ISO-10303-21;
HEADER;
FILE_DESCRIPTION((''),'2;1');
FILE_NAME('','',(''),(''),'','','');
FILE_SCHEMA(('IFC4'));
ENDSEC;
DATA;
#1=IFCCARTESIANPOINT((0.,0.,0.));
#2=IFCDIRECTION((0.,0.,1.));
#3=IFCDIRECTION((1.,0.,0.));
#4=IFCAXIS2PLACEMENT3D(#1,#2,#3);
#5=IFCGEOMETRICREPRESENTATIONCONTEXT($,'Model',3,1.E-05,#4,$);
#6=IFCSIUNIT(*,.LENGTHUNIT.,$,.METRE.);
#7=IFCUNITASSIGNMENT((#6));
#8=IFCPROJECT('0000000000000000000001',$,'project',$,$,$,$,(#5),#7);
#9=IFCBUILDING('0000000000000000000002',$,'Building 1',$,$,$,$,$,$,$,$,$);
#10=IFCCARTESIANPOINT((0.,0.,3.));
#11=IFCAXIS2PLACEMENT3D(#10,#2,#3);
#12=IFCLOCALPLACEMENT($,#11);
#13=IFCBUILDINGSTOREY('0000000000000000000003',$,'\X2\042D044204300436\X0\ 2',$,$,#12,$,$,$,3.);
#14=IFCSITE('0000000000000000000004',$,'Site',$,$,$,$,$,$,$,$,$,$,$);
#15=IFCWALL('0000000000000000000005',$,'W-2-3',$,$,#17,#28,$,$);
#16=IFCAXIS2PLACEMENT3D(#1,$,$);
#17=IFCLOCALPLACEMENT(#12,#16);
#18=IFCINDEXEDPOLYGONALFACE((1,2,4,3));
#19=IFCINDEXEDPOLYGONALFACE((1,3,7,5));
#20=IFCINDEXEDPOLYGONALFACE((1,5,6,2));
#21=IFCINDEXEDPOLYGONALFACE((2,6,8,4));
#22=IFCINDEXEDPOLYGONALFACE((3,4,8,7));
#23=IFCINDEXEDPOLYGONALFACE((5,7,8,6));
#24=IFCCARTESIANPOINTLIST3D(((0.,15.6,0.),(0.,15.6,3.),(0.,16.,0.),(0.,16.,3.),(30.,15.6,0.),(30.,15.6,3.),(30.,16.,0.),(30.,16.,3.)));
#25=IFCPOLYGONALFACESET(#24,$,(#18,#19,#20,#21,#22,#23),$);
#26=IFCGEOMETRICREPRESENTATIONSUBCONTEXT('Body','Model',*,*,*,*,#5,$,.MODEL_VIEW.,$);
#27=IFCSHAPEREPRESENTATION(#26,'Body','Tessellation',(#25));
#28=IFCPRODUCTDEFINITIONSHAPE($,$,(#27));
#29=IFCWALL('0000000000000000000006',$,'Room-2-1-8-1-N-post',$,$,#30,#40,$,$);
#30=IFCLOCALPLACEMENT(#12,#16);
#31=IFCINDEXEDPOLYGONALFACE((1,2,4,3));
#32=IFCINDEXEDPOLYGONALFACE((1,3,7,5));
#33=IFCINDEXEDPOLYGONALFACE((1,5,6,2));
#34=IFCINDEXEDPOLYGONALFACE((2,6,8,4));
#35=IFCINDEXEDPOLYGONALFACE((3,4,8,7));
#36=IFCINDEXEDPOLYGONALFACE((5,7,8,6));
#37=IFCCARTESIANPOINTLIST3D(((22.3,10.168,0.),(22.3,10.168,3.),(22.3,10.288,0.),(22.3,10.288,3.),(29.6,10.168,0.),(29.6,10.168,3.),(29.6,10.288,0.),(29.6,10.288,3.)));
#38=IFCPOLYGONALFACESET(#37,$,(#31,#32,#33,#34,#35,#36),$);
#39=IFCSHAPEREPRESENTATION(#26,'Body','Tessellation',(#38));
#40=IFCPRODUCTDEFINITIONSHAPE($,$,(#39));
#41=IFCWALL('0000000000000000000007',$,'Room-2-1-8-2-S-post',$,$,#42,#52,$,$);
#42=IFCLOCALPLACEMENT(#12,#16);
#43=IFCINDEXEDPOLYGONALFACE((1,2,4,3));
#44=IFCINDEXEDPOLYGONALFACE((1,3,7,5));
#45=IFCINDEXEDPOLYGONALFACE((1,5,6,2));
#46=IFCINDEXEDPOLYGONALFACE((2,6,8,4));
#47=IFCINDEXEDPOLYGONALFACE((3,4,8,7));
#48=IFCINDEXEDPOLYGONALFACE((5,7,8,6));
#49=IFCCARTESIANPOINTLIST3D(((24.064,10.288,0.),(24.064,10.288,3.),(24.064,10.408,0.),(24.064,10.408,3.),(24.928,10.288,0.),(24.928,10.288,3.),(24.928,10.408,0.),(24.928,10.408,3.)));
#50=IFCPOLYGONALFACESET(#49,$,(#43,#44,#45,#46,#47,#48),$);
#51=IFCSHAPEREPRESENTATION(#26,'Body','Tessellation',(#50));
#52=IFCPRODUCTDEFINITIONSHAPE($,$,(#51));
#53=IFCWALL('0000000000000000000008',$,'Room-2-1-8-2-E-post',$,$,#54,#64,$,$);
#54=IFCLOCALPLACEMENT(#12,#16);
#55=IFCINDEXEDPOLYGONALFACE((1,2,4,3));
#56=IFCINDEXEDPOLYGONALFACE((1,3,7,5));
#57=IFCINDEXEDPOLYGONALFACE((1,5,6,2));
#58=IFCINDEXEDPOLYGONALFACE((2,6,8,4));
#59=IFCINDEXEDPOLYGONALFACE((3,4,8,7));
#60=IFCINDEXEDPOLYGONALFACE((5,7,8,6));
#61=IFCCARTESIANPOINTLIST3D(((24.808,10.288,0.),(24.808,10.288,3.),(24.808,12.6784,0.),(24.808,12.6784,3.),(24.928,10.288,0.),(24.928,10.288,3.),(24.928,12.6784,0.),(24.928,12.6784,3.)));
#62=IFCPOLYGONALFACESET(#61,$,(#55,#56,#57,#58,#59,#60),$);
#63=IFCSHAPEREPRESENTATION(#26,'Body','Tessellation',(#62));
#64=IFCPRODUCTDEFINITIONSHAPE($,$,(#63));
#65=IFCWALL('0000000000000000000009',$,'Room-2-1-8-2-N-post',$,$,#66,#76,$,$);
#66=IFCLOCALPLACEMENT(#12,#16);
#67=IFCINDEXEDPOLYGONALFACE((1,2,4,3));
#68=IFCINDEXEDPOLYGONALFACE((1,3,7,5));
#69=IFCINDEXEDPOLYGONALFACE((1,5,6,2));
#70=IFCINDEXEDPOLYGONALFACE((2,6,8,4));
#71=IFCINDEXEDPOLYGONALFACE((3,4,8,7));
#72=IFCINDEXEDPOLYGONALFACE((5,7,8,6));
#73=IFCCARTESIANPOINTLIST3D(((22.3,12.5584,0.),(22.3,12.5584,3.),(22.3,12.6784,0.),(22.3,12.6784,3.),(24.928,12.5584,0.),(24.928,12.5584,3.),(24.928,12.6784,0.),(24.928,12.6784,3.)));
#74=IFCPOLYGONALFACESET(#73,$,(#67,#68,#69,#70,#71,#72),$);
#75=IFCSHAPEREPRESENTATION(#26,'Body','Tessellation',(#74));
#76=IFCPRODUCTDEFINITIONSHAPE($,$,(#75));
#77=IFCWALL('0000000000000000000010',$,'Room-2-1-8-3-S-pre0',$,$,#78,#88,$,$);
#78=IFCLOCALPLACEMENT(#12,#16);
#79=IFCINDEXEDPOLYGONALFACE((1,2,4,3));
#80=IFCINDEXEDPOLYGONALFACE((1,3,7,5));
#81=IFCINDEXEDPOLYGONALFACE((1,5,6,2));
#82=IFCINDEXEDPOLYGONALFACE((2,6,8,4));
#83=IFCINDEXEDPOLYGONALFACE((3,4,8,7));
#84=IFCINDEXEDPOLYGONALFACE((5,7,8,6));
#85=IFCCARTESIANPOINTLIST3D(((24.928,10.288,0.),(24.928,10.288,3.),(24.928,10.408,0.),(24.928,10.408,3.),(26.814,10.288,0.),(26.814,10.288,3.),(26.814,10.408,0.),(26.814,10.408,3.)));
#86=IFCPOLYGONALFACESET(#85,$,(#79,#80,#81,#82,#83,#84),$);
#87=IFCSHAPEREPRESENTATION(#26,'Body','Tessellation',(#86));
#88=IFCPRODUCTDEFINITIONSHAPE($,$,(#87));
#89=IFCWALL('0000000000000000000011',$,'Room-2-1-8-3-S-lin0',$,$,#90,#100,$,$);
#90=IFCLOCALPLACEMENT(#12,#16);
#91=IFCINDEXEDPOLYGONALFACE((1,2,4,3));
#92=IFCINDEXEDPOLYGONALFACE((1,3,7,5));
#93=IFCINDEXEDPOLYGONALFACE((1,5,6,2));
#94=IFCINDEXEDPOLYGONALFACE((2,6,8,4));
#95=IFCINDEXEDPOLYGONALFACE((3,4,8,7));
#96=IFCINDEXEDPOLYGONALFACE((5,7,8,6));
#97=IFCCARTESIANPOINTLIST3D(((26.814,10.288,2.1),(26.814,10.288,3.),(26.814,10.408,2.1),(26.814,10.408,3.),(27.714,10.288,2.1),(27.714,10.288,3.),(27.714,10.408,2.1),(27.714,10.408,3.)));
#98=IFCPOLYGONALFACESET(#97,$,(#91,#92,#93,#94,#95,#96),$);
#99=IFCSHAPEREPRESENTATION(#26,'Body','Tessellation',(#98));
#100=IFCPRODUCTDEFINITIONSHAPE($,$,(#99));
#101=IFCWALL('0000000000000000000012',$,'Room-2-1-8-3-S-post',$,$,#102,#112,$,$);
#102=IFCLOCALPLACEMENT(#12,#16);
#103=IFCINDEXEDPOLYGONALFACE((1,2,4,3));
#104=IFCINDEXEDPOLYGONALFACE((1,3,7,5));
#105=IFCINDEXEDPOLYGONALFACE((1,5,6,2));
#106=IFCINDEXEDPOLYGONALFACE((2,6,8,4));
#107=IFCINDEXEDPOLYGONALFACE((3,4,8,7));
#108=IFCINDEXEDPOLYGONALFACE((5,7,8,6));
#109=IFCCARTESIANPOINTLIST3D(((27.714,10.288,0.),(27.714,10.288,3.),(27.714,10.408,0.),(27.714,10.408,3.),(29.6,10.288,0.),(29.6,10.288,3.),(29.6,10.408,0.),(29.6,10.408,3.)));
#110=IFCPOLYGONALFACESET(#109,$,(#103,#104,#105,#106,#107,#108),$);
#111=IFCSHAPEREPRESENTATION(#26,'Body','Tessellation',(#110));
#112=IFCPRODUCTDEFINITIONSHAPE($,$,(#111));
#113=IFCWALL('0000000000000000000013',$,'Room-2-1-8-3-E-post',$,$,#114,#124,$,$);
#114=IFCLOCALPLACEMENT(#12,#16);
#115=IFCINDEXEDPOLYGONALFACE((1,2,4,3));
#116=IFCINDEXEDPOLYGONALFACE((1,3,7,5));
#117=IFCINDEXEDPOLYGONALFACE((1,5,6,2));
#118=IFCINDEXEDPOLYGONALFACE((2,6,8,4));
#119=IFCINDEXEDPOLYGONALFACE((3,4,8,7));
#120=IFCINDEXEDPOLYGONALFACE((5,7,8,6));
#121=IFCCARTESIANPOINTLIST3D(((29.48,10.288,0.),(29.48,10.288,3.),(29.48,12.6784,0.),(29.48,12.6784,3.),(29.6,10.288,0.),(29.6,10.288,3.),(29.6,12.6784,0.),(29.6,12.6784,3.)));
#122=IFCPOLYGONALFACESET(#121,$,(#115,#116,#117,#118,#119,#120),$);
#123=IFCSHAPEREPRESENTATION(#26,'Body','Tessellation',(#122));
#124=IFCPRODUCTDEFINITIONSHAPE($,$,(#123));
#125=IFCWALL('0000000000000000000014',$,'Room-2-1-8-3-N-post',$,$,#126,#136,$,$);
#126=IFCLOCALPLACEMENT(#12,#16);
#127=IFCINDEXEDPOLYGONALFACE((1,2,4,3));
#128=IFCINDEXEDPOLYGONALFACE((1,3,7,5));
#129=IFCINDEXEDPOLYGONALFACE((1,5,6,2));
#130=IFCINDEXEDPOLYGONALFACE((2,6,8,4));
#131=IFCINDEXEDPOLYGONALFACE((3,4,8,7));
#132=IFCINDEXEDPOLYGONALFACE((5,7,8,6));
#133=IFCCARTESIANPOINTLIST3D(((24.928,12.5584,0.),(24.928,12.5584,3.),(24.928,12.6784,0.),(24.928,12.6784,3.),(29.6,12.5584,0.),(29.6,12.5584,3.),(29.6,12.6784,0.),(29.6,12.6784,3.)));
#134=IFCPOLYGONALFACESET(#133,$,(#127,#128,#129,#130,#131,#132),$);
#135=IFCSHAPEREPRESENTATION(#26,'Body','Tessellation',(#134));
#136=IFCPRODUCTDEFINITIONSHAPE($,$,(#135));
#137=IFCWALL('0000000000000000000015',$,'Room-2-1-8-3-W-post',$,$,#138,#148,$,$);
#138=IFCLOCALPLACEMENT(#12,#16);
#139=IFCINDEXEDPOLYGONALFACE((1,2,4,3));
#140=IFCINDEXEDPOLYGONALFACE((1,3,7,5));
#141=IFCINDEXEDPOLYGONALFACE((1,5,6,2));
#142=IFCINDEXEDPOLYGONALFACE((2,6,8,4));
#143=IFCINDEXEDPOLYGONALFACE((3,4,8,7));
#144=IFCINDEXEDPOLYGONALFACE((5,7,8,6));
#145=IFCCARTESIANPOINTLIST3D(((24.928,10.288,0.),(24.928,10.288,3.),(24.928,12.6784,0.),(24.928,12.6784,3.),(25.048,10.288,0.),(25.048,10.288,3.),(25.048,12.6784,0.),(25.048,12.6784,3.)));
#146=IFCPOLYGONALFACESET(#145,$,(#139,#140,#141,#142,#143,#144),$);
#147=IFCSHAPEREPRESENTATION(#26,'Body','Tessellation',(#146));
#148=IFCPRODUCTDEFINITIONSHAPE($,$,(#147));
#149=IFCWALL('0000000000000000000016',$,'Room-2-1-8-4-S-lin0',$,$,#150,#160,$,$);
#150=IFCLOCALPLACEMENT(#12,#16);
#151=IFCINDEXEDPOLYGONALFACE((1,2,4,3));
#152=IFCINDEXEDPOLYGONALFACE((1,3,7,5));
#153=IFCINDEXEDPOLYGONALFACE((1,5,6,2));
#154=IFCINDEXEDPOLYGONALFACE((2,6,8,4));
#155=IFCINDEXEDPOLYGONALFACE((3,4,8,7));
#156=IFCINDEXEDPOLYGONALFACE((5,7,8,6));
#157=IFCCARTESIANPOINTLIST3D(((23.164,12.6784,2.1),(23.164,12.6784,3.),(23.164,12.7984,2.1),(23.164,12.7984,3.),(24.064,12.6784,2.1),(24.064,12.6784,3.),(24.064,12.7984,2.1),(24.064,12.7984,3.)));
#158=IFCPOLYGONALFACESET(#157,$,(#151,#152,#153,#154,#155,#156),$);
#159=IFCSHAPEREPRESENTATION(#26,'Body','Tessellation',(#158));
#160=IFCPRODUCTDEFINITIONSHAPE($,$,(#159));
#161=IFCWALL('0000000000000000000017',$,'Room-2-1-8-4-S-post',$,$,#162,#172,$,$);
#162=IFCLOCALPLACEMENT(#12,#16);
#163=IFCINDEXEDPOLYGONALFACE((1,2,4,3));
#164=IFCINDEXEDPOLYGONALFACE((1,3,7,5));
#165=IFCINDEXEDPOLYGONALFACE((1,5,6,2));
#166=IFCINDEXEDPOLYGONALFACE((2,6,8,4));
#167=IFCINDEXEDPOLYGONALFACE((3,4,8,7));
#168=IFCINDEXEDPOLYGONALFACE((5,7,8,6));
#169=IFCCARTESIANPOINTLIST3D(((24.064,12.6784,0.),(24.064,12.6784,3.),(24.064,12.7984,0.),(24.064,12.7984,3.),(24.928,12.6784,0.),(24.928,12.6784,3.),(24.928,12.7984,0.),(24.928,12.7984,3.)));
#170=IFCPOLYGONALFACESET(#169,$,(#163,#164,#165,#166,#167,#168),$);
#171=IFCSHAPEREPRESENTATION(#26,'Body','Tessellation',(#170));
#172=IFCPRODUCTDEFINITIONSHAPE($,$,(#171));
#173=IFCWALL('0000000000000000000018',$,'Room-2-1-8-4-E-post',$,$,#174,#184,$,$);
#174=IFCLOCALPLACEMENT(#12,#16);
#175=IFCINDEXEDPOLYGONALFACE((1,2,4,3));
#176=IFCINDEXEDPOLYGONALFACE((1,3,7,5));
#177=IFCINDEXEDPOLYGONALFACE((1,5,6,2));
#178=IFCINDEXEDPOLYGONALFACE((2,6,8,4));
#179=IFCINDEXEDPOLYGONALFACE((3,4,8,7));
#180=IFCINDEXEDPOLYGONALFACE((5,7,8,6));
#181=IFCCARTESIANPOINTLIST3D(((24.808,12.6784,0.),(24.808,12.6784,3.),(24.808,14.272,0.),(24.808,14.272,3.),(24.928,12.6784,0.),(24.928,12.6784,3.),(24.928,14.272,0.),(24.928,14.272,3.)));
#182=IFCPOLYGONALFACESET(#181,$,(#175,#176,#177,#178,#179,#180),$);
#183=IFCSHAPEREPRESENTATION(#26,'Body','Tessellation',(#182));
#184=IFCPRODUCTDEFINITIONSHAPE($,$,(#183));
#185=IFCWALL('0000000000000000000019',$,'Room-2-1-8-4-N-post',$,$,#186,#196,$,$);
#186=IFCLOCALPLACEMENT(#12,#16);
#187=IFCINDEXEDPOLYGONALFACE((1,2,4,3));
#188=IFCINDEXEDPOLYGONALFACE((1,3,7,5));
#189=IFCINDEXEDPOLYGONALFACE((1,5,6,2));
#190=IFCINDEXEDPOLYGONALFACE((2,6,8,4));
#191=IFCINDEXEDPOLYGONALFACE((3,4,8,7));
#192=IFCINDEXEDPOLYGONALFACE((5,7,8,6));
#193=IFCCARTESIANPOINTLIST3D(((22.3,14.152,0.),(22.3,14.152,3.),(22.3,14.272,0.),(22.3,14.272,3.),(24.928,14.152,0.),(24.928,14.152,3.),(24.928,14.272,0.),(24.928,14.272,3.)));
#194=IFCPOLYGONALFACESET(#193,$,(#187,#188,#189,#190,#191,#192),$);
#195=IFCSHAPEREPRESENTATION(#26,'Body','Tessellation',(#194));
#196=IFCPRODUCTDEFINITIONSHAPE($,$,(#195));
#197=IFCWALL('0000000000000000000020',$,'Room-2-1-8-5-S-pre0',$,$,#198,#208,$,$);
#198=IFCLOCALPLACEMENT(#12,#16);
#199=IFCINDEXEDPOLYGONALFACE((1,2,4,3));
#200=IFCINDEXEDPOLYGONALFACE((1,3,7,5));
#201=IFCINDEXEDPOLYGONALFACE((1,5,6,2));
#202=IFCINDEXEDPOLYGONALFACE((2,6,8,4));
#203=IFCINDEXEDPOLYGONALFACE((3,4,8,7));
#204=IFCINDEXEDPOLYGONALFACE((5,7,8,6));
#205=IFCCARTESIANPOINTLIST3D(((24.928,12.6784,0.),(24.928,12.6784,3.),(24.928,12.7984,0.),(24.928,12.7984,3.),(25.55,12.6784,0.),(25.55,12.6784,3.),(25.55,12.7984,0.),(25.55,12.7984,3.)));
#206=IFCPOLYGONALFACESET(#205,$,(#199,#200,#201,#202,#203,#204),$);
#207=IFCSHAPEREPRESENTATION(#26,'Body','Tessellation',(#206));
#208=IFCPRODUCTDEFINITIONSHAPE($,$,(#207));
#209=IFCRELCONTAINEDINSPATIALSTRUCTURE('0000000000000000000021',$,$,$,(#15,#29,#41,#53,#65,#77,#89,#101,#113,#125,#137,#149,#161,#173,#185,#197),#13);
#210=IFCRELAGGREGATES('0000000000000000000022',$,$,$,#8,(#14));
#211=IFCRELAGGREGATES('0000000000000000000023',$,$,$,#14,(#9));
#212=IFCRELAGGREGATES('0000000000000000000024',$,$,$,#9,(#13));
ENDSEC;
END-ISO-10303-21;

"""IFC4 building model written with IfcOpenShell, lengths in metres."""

from ifc_helpers import new_model, si_unit, frame, origin_with_axes, place, context, subcontext, project, spatial, indexed_curve, outline, extrude, element, save


model = new_model("IFC4")

# Units and contexts
model_context = context("Model", 3, precision=1e-05, world=origin_with_axes())
body_context = subcontext(model_context, "Body", "Model", "MODEL_VIEW")
ifc_project = project(units=[si_unit("LENGTHUNIT", "METRE")], contexts=[model_context])

# Site, building, storey
site = spatial("IfcSite", under=ifc_project, Name="Site")
building = spatial("IfcBuilding", under=site, Name="Building 1")
storey_placement = place(None, frame((0.0, 0.0, 3.0), z_axis=(0.0, 0.0, 1.0), x_axis=(1.0, 0.0, 0.0)))
storey = spatial("IfcBuildingStorey", under=building, at=storey_placement, Name="Этаж 2", Elevation=3.0)

# Walls
wall_1_placement = place(storey_placement, frame((30.0, 16.0, 0.0), z_axis=(0.0, 0.0, 1.0), x_axis=(-1.0, 0.0, 0.0)))
element("IfcWall", 1, at=wall_1_placement, inside=storey, Name="W-2-3", context=body_context, shape_type="SweptSolid", body=[
    extrude(outline(indexed_curve([(0.0, 0.0), (0.0, 0.4), (30.0, 0.4), (30.0, 0.0), (0.0, 0.0)], self_intersect=False)), origin_with_axes(), (0.0, 0.0, 1.0), 3.0),
])
wall_2_placement = place(storey_placement, frame((29.6, 10.288, 0.0), z_axis=(0.0, 0.0, 1.0), x_axis=(-1.0, 0.0, 0.0)))
element("IfcWall", 2, at=wall_2_placement, inside=storey, Name="Room-2-1-8-1-N-post", context=body_context, shape_type="SweptSolid", body=[
    extrude(outline(indexed_curve([(0.0, 0.0), (0.0, 0.12), (7.3, 0.12), (7.3, 0.0), (0.0, 0.0)], self_intersect=False)), origin_with_axes(), (0.0, 0.0, 1.0), 3.0),
])
wall_3_placement = place(storey_placement, frame((24.064, 10.288, 0.0), z_axis=(0.0, 0.0, 1.0), x_axis=(1.0, 0.0, 0.0)))
element("IfcWall", 3, at=wall_3_placement, inside=storey, Name="Room-2-1-8-2-S-post", context=body_context, shape_type="SweptSolid", body=[
    extrude(outline(indexed_curve([(0.0, 0.0), (0.0, 0.12), (0.864, 0.12), (0.864, 0.0), (0.0, 0.0)], self_intersect=False)), origin_with_axes(), (0.0, 0.0, 1.0), 3.0),
])
wall_4_placement = place(storey_placement, frame((24.928, 10.288, 0.0), z_axis=(0.0, 0.0, 1.0), x_axis=(0.0, 1.0, 0.0)))
element("IfcWall", 4, at=wall_4_placement, inside=storey, Name="Room-2-1-8-2-E-post", context=body_context, shape_type="SweptSolid", body=[
    extrude(outline(indexed_curve([(0.0, 0.0), (0.0, 0.12), (2.3904, 0.12), (2.3904, 0.0), (0.0, 0.0)], self_intersect=False)), origin_with_axes(), (0.0, 0.0, 1.0), 3.0),
])
wall_5_placement = place(storey_placement, frame((24.928, 12.6784, 0.0), z_axis=(0.0, 0.0, 1.0), x_axis=(-1.0, 0.0, 0.0)))
element("IfcWall", 5, at=wall_5_placement, inside=storey, Name="Room-2-1-8-2-N-post", context=body_context, shape_type="SweptSolid", body=[
    extrude(outline(indexed_curve([(0.0, 0.0), (0.0, 0.12), (2.628, 0.12), (2.628, 0.0), (0.0, 0.0)], self_intersect=False)), origin_with_axes(), (0.0, 0.0, 1.0), 3.0),
])
wall_6_placement = place(storey_placement, frame((24.928, 10.288, 0.0), z_axis=(0.0, 0.0, 1.0), x_axis=(1.0, 0.0, 0.0)))
element("IfcWall", 6, at=wall_6_placement, inside=storey, Name="Room-2-1-8-3-S-pre0", context=body_context, shape_type="SweptSolid", body=[
    extrude(outline(indexed_curve([(0.0, 0.0), (0.0, 0.12), (1.886, 0.12), (1.886, 0.0), (0.0, 0.0)], self_intersect=False)), origin_with_axes(), (0.0, 0.0, 1.0), 3.0),
])
wall_7_placement = place(storey_placement, frame((26.814, 10.288, 2.1), z_axis=(0.0, 0.0, 1.0), x_axis=(1.0, 0.0, 0.0)))
element("IfcWall", 7, at=wall_7_placement, inside=storey, Name="Room-2-1-8-3-S-lin0", context=body_context, shape_type="SweptSolid", body=[
    extrude(outline(indexed_curve([(0.0, 0.0), (0.0, 0.12), (0.9, 0.12), (0.9, 0.0), (0.0, 0.0)], self_intersect=False)), origin_with_axes(), (0.0, 0.0, 1.0), 0.9),
])
wall_8_placement = place(storey_placement, frame((27.714, 10.288, 0.0), z_axis=(0.0, 0.0, 1.0), x_axis=(1.0, 0.0, 0.0)))
element("IfcWall", 8, at=wall_8_placement, inside=storey, Name="Room-2-1-8-3-S-post", context=body_context, shape_type="SweptSolid", body=[
    extrude(outline(indexed_curve([(0.0, 0.0), (0.0, 0.12), (1.886, 0.12), (1.886, 0.0), (0.0, 0.0)], self_intersect=False)), origin_with_axes(), (0.0, 0.0, 1.0), 3.0),
])
wall_9_placement = place(storey_placement, frame((29.6, 10.288, 0.0), z_axis=(0.0, 0.0, 1.0), x_axis=(0.0, 1.0, 0.0)))
element("IfcWall", 9, at=wall_9_placement, inside=storey, Name="Room-2-1-8-3-E-post", context=body_context, shape_type="SweptSolid", body=[
    extrude(outline(indexed_curve([(0.0, 0.0), (0.0, 0.12), (2.3904, 0.12), (2.3904, 0.0), (0.0, 0.0)], self_intersect=False)), origin_with_axes(), (0.0, 0.0, 1.0), 3.0),
])
wall_10_placement = place(storey_placement, frame((29.6, 12.6784, 0.0), z_axis=(0.0, 0.0, 1.0), x_axis=(-1.0, 0.0, 0.0)))
element("IfcWall", 10, at=wall_10_placement, inside=storey, Name="Room-2-1-8-3-N-post", context=body_context, shape_type="SweptSolid", body=[
    extrude(outline(indexed_curve([(0.0, 0.0), (0.0, 0.12), (4.672, 0.12), (4.672, 0.0), (0.0, 0.0)], self_intersect=False)), origin_with_axes(), (0.0, 0.0, 1.0), 3.0),
])
wall_11_placement = place(storey_placement, frame((24.928, 12.6784, 0.0), z_axis=(0.0, 0.0, 1.0), x_axis=(0.0, -1.0, 0.0)))
element("IfcWall", 11, at=wall_11_placement, inside=storey, Name="Room-2-1-8-3-W-post", context=body_context, shape_type="SweptSolid", body=[
    extrude(outline(indexed_curve([(0.0, 0.0), (0.0, 0.12), (2.3904, 0.12), (2.3904, 0.0), (0.0, 0.0)], self_intersect=False)), origin_with_axes(), (0.0, 0.0, 1.0), 3.0),
])
wall_12_placement = place(storey_placement, frame((23.164, 12.6784, 2.1), z_axis=(0.0, 0.0, 1.0), x_axis=(1.0, 0.0, 0.0)))
element("IfcWall", 12, at=wall_12_placement, inside=storey, Name="Room-2-1-8-4-S-lin0", context=body_context, shape_type="SweptSolid", body=[
    extrude(outline(indexed_curve([(0.0, 0.0), (0.0, 0.12), (0.9, 0.12), (0.9, 0.0), (0.0, 0.0)], self_intersect=False)), origin_with_axes(), (0.0, 0.0, 1.0), 0.9),
])
wall_13_placement = place(storey_placement, frame((24.064, 12.6784, 0.0), z_axis=(0.0, 0.0, 1.0), x_axis=(1.0, 0.0, 0.0)))
element("IfcWall", 13, at=wall_13_placement, inside=storey, Name="Room-2-1-8-4-S-post", context=body_context, shape_type="SweptSolid", body=[
    extrude(outline(indexed_curve([(0.0, 0.0), (0.0, 0.12), (0.864, 0.12), (0.864, 0.0), (0.0, 0.0)], self_intersect=False)), origin_with_axes(), (0.0, 0.0, 1.0), 3.0),
])
wall_14_placement = place(storey_placement, frame((24.928, 12.6784, 0.0), z_axis=(0.0, 0.0, 1.0), x_axis=(0.0, 1.0, 0.0)))
element("IfcWall", 14, at=wall_14_placement, inside=storey, Name="Room-2-1-8-4-E-post", context=body_context, shape_type="SweptSolid", body=[
    extrude(outline(indexed_curve([(0.0, 0.0), (0.0, 0.12), (1.5936, 0.12), (1.5936, 0.0), (0.0, 0.0)], self_intersect=False)), origin_with_axes(), (0.0, 0.0, 1.0), 3.0),
])
wall_15_placement = place(storey_placement, frame((24.928, 14.272, 0.0), z_axis=(0.0, 0.0, 1.0), x_axis=(-1.0, 0.0, 0.0)))
element("IfcWall", 15, at=wall_15_placement, inside=storey, Name="Room-2-1-8-4-N-post", context=body_context, shape_type="SweptSolid", body=[
    extrude(outline(indexed_curve([(0.0, 0.0), (0.0, 0.12), (2.628, 0.12), (2.628, 0.0), (0.0, 0.0)], self_intersect=False)), origin_with_axes(), (0.0, 0.0, 1.0), 3.0),
])
wall_16_placement = place(storey_placement, frame((24.928, 12.6784, 0.0), z_axis=(0.0, 0.0, 1.0), x_axis=(1.0, 0.0, 0.0)))
element("IfcWall", 16, at=wall_16_placement, inside=storey, Name="Room-2-1-8-5-S-pre0", context=body_context, shape_type="SweptSolid", body=[
    extrude(outline(indexed_curve([(0.0, 0.0), (0.0, 0.12), (0.622, 0.12), (0.622, 0.0), (0.0, 0.0)], self_intersect=False)), origin_with_axes(), (0.0, 0.0, 1.0), 3.0),
])

save(model, "model.ifc")
